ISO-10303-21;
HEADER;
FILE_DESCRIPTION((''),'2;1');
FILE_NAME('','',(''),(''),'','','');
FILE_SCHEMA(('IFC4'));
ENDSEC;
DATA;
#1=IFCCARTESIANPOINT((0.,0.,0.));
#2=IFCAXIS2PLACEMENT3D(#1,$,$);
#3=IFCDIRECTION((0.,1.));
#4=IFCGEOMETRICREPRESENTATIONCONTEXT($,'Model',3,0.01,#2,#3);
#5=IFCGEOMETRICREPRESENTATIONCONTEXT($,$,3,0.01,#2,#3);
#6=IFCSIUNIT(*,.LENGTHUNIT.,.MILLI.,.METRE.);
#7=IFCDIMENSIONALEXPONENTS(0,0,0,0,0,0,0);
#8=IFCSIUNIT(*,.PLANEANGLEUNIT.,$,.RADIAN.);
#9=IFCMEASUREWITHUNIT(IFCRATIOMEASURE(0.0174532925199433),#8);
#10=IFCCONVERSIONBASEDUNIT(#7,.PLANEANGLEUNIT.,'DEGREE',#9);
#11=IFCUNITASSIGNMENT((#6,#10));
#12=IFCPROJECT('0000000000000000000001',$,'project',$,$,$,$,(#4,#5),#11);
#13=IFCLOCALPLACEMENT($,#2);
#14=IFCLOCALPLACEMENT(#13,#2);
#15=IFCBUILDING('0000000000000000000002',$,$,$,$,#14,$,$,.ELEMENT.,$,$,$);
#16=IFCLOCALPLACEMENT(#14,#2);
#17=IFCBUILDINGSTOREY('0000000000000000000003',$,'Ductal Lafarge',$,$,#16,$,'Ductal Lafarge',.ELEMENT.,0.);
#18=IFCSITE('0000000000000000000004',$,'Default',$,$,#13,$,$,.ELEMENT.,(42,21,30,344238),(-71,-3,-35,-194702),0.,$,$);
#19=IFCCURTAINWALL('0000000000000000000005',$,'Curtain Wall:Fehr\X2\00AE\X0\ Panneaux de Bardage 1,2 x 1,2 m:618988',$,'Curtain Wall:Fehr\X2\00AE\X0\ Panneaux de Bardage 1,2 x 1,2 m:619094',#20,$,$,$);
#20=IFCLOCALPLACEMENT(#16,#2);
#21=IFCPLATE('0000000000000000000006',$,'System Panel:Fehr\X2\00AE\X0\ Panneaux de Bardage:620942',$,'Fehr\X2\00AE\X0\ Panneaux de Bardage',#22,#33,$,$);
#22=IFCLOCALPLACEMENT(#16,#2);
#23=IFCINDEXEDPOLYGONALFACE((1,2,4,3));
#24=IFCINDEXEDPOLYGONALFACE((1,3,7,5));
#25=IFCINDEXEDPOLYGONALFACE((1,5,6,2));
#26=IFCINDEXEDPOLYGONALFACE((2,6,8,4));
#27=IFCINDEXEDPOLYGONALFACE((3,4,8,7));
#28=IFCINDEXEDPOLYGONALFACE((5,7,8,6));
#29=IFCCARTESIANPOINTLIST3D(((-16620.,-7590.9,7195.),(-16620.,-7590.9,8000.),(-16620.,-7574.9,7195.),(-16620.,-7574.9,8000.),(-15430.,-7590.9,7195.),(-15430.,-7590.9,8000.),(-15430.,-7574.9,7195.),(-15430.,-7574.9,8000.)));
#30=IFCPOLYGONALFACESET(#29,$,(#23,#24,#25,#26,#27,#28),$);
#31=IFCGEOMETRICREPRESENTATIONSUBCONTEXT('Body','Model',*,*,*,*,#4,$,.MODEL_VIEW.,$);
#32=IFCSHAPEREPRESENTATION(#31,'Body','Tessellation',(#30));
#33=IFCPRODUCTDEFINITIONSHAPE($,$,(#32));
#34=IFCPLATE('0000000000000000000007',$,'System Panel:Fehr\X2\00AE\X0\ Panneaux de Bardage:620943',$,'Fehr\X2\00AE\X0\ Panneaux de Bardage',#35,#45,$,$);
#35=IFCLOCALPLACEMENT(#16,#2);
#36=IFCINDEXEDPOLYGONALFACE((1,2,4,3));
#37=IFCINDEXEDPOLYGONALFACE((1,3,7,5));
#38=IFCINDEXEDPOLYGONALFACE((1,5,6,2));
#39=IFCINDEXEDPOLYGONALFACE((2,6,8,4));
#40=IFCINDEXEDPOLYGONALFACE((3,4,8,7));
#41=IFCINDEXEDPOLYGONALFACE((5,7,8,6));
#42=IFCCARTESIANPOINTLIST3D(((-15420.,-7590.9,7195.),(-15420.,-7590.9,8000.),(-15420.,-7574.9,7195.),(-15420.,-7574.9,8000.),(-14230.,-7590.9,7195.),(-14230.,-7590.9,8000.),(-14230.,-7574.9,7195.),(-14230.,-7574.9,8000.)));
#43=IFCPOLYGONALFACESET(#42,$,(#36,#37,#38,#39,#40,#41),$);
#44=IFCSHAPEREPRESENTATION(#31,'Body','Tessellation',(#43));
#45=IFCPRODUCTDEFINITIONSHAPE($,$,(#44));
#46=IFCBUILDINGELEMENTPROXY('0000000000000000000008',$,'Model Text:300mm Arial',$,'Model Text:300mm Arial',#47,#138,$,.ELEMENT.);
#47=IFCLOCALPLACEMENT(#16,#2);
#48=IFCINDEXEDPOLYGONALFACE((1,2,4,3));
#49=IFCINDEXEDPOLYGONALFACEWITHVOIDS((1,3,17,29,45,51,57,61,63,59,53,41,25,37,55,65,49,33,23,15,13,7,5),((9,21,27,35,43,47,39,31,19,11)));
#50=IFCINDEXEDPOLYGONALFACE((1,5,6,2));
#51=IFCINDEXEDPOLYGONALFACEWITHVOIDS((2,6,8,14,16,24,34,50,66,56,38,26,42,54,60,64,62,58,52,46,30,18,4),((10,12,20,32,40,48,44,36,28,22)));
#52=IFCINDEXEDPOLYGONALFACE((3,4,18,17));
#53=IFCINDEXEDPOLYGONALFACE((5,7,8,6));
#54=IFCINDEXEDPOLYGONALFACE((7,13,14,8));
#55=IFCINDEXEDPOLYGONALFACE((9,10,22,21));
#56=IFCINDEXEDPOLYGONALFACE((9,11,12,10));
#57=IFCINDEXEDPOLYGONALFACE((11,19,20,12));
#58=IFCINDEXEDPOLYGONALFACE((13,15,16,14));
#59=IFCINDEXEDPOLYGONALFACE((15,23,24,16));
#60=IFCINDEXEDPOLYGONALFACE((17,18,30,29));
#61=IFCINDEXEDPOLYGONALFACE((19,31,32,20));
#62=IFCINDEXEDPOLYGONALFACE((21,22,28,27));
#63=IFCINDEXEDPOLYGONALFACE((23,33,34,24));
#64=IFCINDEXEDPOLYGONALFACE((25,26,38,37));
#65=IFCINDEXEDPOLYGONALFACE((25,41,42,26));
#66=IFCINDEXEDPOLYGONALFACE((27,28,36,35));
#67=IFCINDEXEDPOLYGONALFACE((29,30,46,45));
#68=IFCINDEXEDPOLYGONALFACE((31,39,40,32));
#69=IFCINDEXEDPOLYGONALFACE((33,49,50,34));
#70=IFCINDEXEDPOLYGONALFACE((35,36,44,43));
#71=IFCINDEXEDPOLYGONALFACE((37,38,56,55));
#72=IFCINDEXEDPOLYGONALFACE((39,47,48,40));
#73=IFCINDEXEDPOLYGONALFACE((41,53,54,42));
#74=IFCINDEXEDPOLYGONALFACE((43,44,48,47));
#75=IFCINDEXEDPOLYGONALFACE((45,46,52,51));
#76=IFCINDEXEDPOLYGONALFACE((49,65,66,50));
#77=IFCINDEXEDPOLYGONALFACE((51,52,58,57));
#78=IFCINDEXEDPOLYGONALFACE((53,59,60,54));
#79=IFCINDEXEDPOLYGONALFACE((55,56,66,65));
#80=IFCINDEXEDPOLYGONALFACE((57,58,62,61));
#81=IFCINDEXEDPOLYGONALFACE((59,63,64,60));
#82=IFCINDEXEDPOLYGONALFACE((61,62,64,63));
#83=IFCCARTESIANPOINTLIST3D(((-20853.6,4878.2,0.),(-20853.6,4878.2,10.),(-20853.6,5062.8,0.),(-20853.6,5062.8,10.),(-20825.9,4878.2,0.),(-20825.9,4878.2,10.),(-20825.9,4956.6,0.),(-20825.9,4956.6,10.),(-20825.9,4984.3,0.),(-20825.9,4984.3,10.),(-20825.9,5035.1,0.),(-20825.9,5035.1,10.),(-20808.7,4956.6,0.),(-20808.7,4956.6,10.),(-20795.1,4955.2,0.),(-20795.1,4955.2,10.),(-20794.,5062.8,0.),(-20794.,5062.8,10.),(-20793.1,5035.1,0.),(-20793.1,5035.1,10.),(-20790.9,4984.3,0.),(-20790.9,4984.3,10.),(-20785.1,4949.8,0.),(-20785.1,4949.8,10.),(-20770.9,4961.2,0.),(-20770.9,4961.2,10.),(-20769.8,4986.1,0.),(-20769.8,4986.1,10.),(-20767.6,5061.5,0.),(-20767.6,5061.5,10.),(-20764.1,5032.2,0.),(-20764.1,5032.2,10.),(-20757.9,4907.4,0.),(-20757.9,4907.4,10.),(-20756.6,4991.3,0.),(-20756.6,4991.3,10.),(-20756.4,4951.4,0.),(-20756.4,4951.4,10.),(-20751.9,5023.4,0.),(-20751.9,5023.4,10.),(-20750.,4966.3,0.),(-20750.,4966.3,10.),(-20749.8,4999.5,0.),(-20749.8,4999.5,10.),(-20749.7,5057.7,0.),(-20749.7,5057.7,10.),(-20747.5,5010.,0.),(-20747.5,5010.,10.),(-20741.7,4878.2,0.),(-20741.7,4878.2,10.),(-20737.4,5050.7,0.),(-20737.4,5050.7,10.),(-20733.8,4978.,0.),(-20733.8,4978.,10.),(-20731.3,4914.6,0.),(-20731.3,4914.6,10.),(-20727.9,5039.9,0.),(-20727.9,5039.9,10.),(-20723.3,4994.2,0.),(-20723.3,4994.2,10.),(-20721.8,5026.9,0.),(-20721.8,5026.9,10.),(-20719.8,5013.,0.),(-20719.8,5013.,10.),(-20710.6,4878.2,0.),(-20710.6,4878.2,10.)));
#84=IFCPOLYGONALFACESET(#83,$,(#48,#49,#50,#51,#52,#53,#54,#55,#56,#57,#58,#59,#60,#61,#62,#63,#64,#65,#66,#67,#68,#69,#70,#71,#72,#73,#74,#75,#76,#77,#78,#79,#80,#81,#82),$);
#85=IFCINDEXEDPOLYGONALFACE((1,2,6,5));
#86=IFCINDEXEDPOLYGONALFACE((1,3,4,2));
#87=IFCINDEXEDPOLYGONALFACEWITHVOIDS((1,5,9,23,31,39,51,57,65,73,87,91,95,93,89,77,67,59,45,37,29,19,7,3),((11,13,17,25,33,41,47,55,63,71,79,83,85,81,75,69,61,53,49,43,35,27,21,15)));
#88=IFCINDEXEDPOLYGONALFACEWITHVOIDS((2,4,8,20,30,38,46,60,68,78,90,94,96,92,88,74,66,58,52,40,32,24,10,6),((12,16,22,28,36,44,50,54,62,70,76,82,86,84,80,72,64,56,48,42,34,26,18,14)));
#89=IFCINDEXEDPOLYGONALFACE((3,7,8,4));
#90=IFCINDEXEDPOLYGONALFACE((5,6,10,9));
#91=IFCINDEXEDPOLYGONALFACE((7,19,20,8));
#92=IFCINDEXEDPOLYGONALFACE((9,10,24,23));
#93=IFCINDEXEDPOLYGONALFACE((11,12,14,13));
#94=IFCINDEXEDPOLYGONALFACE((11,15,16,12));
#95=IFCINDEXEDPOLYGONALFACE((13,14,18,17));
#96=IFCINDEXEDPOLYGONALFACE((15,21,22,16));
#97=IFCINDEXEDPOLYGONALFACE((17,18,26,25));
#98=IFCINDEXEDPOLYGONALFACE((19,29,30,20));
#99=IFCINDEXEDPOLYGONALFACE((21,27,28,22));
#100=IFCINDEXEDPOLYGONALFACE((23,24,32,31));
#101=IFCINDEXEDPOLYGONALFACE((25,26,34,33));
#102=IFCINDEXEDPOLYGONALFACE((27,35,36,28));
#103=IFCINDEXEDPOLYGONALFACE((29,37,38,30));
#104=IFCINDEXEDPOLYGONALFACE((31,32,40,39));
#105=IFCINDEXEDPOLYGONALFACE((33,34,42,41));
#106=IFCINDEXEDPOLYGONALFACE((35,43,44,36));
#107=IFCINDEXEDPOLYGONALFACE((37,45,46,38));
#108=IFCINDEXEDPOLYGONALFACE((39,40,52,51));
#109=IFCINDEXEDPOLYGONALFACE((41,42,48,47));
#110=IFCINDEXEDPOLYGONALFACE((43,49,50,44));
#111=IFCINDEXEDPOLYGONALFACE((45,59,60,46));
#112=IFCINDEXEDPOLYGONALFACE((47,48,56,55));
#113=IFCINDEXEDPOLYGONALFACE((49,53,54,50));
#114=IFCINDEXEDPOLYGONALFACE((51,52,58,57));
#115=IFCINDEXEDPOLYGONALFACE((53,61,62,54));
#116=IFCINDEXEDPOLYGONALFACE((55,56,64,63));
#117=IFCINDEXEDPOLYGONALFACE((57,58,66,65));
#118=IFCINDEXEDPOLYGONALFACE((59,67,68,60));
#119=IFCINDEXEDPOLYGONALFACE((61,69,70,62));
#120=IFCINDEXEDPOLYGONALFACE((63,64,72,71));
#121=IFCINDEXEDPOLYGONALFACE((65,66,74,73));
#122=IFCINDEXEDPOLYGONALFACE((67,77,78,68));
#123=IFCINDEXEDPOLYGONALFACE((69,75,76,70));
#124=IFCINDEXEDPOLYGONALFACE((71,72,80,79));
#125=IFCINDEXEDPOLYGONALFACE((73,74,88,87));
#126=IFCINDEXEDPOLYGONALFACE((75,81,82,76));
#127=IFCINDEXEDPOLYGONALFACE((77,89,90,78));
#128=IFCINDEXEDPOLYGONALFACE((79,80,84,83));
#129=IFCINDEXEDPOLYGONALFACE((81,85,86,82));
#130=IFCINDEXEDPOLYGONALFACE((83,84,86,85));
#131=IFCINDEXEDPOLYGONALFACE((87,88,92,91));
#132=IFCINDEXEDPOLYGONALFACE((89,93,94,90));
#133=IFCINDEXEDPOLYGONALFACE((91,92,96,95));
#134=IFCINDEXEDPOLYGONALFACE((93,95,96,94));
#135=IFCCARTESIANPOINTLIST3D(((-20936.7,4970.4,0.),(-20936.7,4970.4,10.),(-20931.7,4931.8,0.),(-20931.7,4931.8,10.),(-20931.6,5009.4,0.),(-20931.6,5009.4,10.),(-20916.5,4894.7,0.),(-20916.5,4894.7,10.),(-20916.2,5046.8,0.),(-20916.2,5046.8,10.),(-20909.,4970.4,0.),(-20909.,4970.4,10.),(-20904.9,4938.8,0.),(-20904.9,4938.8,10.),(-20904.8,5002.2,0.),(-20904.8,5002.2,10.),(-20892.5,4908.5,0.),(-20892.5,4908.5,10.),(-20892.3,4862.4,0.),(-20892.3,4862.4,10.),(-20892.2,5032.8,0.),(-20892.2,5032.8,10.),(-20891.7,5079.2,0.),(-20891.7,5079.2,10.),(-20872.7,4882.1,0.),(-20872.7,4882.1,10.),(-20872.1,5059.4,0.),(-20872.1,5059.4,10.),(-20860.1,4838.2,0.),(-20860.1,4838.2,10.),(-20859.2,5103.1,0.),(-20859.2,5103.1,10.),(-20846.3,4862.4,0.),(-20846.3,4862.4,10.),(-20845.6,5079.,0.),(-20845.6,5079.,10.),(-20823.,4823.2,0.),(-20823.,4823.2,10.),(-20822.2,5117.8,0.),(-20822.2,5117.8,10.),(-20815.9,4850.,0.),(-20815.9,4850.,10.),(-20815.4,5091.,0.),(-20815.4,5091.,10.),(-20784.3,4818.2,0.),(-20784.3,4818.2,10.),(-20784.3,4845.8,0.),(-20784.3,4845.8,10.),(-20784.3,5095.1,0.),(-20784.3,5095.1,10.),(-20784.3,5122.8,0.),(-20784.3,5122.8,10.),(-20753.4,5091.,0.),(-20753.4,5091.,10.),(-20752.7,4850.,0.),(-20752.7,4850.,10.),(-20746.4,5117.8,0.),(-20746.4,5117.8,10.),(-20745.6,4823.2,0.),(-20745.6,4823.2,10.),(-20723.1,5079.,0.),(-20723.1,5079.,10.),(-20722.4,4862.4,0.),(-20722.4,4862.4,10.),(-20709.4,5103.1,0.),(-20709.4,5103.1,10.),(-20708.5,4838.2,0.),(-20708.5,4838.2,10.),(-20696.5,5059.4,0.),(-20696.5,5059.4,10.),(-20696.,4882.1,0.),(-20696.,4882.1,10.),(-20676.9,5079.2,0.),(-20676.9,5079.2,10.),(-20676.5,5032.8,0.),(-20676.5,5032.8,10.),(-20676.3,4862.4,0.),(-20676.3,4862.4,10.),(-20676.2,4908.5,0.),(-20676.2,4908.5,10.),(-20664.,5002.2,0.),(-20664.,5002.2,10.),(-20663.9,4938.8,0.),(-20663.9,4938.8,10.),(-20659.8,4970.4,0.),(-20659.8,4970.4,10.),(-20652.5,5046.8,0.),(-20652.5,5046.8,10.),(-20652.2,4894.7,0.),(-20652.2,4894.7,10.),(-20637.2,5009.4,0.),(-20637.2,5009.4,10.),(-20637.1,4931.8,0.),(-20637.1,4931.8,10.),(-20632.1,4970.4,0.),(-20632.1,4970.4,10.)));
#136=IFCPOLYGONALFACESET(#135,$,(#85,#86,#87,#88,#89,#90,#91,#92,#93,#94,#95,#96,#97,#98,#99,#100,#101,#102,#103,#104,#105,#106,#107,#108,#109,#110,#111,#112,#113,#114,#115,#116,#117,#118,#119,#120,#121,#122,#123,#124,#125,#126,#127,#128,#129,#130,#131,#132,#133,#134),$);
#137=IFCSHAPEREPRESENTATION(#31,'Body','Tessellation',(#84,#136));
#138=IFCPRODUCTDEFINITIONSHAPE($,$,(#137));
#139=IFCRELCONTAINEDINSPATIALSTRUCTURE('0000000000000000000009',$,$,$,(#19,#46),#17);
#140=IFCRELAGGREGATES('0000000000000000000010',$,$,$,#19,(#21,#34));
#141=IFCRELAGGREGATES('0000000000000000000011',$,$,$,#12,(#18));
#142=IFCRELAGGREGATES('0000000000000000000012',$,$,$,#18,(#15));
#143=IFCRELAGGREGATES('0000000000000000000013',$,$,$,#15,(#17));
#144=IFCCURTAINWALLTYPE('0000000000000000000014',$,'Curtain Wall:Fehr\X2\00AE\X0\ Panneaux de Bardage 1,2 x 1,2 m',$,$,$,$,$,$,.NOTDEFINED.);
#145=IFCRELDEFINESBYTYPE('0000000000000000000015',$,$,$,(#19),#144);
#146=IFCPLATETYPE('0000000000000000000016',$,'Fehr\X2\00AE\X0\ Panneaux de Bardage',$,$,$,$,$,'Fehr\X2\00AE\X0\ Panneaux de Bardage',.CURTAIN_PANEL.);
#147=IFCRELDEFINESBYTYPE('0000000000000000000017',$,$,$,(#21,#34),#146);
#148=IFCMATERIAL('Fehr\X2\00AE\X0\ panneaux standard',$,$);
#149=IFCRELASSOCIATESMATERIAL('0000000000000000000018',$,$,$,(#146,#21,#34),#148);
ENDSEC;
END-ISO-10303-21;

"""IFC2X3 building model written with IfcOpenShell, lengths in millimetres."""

from ifc_helpers import new_model, entity, si_unit, converted_unit, direction, frame, origin, origin_2d_with_axis, place, context, subcontext, project, spatial, polyline, rectangle, outline, extrude, source, transform, mapped, material, type_object, type_shapes, element, aggregate, save


model = new_model("IFC2X3")

# Units and contexts
model_context = context("Model", 3, precision=0.01, world=origin(), true_north=direction((0.0, 1.0)))
context_of_model = context(None, 3, precision=0.01, world=origin(), true_north=direction((0.0, 1.0)))
body_context = subcontext(model_context, "Body", "Model", "MODEL_VIEW")
ifc_project = project(units=[si_unit("LENGTHUNIT", "METRE", prefix="MILLI"), converted_unit("PLANEANGLEUNIT", "DEGREE", entity("IfcRatioMeasure", 0.0174532925199433), si_unit("PLANEANGLEUNIT", "RADIAN"), dimensions=[0, 0, 0, 0, 0, 0, 0])], contexts=[model_context, context_of_model])

# Site, building, storey
site_placement = place(None, origin())
site = spatial("IfcSite", under=ifc_project, at=site_placement, Name="Default", CompositionType="ELEMENT", RefLatitude=(42, 21, 30, 344238), RefLongitude=(-71, -3, -35, -194702), RefElevation=0.0)
building_placement = place(site_placement, origin())
building = spatial("IfcBuilding", under=site, at=building_placement, CompositionType="ELEMENT")
storey_placement = place(building_placement, origin())
storey = spatial("IfcBuildingStorey", under=building, at=storey_placement, Name="Ductal Lafarge", LongName="Ductal Lafarge", CompositionType="ELEMENT", Elevation=0.0)

# Curtain wall, plates
curtain_wall_type = type_object("IfcCurtainWallType", Name="Curtain Wall:Fehr® Panneaux de Bardage 1,2 x 1,2 m", PredefinedType="NOTDEFINED")
curtain_wall_placement = place(storey_placement, origin())
curtain_wall = element("IfcCurtainWall", 1, at=curtain_wall_placement, inside=storey, type_object=curtain_wall_type, Name="Curtain Wall:Fehr® Panneaux de Bardage 1,2 x 1,2 m:618988", ObjectType="Curtain Wall:Fehr® Panneaux de Bardage 1,2 x 1,2 m:619094")
ifc_material_1 = material(Name="Fehr® panneaux standard")
plate_type_1 = type_object("IfcPlateType", Name="Fehr® Panneaux de Bardage", ElementType="Fehr® Panneaux de Bardage", PredefinedType="CURTAIN_PANEL", material=ifc_material_1)
shared_shape_1 = source(origin(), body_context, "Body", "SweptSolid", [
    extrude(rectangle(XDim=16.0, YDim=1190.0, at=origin_2d_with_axis()), frame((0.0, 0.0, 0.0), z_axis=(0.0, 0.0, 1.0), x_axis=(0.0, 1.0, 0.0)), (0.0, 0.0, 1.0), 805.0),
])
type_shapes(plate_type_1, [shared_shape_1])
plate_1_placement = place(curtain_wall_placement, frame((-16025.0, -7582.9, 7195.0)))
plate_1 = element("IfcPlate", 2, at=plate_1_placement, type_object=plate_type_1, material=ifc_material_1, Name="System Panel:Fehr® Panneaux de Bardage:620942", ObjectType="Fehr® Panneaux de Bardage", context=body_context, shape_type="MappedRepresentation", body=[
    mapped(shared_shape_1, transform((0.0, 0.0, 0.0), scale=1.0)),
])
plate_2_placement = place(curtain_wall_placement, frame((-14825.0, -7582.9, 7195.0)))
plate_2 = element("IfcPlate", 3, at=plate_2_placement, type_object=plate_type_1, material=ifc_material_1, Name="System Panel:Fehr® Panneaux de Bardage:620943", ObjectType="Fehr® Panneaux de Bardage", context=body_context, shape_type="MappedRepresentation", body=[
    mapped(shared_shape_1, transform((0.0, 0.0, 0.0), scale=1.0)),
])
aggregate(curtain_wall, [plate_1, plate_2])

# Building element proxy
proxy_1_placement = place(storey_placement, frame((-20936.7, 4818.2, 0.0)))
element("IfcBuildingElementProxy", 4, at=proxy_1_placement, inside=storey, Name="Model Text:300mm Arial", ObjectType="Model Text:300mm Arial", CompositionType="ELEMENT", context=body_context, shape_type="SweptSolid", body=[
    extrude(outline(polyline([(-86.6, -94.9), (-58.9, -94.9), (-58.9, -16.4), (-41.7, -16.4), (-28.0, -17.8), (-18.1, -23.2), (9.1, -65.6), (25.3, -94.9), (56.5, -94.9), (35.8, -58.4), (10.6, -21.6), (-3.8, -11.8), (17.0, -6.7), (33.3, 5.0), (43.8, 21.2), (47.3, 40.0), (45.2, 53.9), (39.1, 66.9), (29.6, 77.7), (17.3, 84.7), (-0.6, 88.5), (-26.9, 89.8), (-86.6, 89.8), (-86.6, -94.9)]), holes=[polyline([(-58.9, 11.3), (-58.9, 62.1), (-26.1, 62.1), (2.9, 59.2), (15.2, 50.4), (19.6, 37.0), (17.3, 26.5), (10.4, 18.3), (-2.7, 13.1), (-23.8, 11.3), (-58.9, 11.3)])]), frame((169.7, 154.9, 0.0)), (0.0, 0.0, 1.0), 10.0),
    extrude(outline(polyline([(-19.6, -150.9), (18.6, -150.9), (57.1, -141.0), (92.5, -121.5), (121.0, -92.5), (141.0, -57.4), (151.1, -19.4), (151.1, 19.5), (140.9, 58.3), (121.0, 93.4), (92.2, 121.5), (57.4, 141.2), (19.6, 151.2), (-19.4, 151.2), (-58.1, 141.0), (-93.2, 121.2), (-121.3, 92.3), (-141.0, 57.5), (-150.9, 19.8), (-150.9, -19.4), (-140.6, -58.5), (-120.5, -93.8), (-91.4, -121.7), (-56.6, -141.1), (-19.6, -150.9)]), holes=[polyline([(-16.1, -123.4), (-46.2, -115.4), (-74.7, -99.6), (-98.5, -76.7), (-114.9, -47.8), (-123.4, -15.8), (-123.5, 16.3), (-115.3, 47.1), (-99.2, 75.5), (-76.2, 99.1), (-47.5, 115.3), (-15.8, 123.7), (16.1, 123.7), (46.9, 115.6), (75.4, 99.4), (99.0, 76.3), (115.3, 47.7), (123.7, 16.0), (123.7, -15.9), (115.4, -46.9), (98.9, -75.6), (75.6, -99.3), (46.7, -115.3), (15.2, -123.4), (-16.1, -123.4)])]), frame((152.4, 152.5, 0.0), z_axis=(0.0, 0.0, 1.0), x_axis=(-0.991656, -0.128915, 0.0)), (0.0, 0.0, 1.0), 10.0),
])

save(model, "model.ifc")
